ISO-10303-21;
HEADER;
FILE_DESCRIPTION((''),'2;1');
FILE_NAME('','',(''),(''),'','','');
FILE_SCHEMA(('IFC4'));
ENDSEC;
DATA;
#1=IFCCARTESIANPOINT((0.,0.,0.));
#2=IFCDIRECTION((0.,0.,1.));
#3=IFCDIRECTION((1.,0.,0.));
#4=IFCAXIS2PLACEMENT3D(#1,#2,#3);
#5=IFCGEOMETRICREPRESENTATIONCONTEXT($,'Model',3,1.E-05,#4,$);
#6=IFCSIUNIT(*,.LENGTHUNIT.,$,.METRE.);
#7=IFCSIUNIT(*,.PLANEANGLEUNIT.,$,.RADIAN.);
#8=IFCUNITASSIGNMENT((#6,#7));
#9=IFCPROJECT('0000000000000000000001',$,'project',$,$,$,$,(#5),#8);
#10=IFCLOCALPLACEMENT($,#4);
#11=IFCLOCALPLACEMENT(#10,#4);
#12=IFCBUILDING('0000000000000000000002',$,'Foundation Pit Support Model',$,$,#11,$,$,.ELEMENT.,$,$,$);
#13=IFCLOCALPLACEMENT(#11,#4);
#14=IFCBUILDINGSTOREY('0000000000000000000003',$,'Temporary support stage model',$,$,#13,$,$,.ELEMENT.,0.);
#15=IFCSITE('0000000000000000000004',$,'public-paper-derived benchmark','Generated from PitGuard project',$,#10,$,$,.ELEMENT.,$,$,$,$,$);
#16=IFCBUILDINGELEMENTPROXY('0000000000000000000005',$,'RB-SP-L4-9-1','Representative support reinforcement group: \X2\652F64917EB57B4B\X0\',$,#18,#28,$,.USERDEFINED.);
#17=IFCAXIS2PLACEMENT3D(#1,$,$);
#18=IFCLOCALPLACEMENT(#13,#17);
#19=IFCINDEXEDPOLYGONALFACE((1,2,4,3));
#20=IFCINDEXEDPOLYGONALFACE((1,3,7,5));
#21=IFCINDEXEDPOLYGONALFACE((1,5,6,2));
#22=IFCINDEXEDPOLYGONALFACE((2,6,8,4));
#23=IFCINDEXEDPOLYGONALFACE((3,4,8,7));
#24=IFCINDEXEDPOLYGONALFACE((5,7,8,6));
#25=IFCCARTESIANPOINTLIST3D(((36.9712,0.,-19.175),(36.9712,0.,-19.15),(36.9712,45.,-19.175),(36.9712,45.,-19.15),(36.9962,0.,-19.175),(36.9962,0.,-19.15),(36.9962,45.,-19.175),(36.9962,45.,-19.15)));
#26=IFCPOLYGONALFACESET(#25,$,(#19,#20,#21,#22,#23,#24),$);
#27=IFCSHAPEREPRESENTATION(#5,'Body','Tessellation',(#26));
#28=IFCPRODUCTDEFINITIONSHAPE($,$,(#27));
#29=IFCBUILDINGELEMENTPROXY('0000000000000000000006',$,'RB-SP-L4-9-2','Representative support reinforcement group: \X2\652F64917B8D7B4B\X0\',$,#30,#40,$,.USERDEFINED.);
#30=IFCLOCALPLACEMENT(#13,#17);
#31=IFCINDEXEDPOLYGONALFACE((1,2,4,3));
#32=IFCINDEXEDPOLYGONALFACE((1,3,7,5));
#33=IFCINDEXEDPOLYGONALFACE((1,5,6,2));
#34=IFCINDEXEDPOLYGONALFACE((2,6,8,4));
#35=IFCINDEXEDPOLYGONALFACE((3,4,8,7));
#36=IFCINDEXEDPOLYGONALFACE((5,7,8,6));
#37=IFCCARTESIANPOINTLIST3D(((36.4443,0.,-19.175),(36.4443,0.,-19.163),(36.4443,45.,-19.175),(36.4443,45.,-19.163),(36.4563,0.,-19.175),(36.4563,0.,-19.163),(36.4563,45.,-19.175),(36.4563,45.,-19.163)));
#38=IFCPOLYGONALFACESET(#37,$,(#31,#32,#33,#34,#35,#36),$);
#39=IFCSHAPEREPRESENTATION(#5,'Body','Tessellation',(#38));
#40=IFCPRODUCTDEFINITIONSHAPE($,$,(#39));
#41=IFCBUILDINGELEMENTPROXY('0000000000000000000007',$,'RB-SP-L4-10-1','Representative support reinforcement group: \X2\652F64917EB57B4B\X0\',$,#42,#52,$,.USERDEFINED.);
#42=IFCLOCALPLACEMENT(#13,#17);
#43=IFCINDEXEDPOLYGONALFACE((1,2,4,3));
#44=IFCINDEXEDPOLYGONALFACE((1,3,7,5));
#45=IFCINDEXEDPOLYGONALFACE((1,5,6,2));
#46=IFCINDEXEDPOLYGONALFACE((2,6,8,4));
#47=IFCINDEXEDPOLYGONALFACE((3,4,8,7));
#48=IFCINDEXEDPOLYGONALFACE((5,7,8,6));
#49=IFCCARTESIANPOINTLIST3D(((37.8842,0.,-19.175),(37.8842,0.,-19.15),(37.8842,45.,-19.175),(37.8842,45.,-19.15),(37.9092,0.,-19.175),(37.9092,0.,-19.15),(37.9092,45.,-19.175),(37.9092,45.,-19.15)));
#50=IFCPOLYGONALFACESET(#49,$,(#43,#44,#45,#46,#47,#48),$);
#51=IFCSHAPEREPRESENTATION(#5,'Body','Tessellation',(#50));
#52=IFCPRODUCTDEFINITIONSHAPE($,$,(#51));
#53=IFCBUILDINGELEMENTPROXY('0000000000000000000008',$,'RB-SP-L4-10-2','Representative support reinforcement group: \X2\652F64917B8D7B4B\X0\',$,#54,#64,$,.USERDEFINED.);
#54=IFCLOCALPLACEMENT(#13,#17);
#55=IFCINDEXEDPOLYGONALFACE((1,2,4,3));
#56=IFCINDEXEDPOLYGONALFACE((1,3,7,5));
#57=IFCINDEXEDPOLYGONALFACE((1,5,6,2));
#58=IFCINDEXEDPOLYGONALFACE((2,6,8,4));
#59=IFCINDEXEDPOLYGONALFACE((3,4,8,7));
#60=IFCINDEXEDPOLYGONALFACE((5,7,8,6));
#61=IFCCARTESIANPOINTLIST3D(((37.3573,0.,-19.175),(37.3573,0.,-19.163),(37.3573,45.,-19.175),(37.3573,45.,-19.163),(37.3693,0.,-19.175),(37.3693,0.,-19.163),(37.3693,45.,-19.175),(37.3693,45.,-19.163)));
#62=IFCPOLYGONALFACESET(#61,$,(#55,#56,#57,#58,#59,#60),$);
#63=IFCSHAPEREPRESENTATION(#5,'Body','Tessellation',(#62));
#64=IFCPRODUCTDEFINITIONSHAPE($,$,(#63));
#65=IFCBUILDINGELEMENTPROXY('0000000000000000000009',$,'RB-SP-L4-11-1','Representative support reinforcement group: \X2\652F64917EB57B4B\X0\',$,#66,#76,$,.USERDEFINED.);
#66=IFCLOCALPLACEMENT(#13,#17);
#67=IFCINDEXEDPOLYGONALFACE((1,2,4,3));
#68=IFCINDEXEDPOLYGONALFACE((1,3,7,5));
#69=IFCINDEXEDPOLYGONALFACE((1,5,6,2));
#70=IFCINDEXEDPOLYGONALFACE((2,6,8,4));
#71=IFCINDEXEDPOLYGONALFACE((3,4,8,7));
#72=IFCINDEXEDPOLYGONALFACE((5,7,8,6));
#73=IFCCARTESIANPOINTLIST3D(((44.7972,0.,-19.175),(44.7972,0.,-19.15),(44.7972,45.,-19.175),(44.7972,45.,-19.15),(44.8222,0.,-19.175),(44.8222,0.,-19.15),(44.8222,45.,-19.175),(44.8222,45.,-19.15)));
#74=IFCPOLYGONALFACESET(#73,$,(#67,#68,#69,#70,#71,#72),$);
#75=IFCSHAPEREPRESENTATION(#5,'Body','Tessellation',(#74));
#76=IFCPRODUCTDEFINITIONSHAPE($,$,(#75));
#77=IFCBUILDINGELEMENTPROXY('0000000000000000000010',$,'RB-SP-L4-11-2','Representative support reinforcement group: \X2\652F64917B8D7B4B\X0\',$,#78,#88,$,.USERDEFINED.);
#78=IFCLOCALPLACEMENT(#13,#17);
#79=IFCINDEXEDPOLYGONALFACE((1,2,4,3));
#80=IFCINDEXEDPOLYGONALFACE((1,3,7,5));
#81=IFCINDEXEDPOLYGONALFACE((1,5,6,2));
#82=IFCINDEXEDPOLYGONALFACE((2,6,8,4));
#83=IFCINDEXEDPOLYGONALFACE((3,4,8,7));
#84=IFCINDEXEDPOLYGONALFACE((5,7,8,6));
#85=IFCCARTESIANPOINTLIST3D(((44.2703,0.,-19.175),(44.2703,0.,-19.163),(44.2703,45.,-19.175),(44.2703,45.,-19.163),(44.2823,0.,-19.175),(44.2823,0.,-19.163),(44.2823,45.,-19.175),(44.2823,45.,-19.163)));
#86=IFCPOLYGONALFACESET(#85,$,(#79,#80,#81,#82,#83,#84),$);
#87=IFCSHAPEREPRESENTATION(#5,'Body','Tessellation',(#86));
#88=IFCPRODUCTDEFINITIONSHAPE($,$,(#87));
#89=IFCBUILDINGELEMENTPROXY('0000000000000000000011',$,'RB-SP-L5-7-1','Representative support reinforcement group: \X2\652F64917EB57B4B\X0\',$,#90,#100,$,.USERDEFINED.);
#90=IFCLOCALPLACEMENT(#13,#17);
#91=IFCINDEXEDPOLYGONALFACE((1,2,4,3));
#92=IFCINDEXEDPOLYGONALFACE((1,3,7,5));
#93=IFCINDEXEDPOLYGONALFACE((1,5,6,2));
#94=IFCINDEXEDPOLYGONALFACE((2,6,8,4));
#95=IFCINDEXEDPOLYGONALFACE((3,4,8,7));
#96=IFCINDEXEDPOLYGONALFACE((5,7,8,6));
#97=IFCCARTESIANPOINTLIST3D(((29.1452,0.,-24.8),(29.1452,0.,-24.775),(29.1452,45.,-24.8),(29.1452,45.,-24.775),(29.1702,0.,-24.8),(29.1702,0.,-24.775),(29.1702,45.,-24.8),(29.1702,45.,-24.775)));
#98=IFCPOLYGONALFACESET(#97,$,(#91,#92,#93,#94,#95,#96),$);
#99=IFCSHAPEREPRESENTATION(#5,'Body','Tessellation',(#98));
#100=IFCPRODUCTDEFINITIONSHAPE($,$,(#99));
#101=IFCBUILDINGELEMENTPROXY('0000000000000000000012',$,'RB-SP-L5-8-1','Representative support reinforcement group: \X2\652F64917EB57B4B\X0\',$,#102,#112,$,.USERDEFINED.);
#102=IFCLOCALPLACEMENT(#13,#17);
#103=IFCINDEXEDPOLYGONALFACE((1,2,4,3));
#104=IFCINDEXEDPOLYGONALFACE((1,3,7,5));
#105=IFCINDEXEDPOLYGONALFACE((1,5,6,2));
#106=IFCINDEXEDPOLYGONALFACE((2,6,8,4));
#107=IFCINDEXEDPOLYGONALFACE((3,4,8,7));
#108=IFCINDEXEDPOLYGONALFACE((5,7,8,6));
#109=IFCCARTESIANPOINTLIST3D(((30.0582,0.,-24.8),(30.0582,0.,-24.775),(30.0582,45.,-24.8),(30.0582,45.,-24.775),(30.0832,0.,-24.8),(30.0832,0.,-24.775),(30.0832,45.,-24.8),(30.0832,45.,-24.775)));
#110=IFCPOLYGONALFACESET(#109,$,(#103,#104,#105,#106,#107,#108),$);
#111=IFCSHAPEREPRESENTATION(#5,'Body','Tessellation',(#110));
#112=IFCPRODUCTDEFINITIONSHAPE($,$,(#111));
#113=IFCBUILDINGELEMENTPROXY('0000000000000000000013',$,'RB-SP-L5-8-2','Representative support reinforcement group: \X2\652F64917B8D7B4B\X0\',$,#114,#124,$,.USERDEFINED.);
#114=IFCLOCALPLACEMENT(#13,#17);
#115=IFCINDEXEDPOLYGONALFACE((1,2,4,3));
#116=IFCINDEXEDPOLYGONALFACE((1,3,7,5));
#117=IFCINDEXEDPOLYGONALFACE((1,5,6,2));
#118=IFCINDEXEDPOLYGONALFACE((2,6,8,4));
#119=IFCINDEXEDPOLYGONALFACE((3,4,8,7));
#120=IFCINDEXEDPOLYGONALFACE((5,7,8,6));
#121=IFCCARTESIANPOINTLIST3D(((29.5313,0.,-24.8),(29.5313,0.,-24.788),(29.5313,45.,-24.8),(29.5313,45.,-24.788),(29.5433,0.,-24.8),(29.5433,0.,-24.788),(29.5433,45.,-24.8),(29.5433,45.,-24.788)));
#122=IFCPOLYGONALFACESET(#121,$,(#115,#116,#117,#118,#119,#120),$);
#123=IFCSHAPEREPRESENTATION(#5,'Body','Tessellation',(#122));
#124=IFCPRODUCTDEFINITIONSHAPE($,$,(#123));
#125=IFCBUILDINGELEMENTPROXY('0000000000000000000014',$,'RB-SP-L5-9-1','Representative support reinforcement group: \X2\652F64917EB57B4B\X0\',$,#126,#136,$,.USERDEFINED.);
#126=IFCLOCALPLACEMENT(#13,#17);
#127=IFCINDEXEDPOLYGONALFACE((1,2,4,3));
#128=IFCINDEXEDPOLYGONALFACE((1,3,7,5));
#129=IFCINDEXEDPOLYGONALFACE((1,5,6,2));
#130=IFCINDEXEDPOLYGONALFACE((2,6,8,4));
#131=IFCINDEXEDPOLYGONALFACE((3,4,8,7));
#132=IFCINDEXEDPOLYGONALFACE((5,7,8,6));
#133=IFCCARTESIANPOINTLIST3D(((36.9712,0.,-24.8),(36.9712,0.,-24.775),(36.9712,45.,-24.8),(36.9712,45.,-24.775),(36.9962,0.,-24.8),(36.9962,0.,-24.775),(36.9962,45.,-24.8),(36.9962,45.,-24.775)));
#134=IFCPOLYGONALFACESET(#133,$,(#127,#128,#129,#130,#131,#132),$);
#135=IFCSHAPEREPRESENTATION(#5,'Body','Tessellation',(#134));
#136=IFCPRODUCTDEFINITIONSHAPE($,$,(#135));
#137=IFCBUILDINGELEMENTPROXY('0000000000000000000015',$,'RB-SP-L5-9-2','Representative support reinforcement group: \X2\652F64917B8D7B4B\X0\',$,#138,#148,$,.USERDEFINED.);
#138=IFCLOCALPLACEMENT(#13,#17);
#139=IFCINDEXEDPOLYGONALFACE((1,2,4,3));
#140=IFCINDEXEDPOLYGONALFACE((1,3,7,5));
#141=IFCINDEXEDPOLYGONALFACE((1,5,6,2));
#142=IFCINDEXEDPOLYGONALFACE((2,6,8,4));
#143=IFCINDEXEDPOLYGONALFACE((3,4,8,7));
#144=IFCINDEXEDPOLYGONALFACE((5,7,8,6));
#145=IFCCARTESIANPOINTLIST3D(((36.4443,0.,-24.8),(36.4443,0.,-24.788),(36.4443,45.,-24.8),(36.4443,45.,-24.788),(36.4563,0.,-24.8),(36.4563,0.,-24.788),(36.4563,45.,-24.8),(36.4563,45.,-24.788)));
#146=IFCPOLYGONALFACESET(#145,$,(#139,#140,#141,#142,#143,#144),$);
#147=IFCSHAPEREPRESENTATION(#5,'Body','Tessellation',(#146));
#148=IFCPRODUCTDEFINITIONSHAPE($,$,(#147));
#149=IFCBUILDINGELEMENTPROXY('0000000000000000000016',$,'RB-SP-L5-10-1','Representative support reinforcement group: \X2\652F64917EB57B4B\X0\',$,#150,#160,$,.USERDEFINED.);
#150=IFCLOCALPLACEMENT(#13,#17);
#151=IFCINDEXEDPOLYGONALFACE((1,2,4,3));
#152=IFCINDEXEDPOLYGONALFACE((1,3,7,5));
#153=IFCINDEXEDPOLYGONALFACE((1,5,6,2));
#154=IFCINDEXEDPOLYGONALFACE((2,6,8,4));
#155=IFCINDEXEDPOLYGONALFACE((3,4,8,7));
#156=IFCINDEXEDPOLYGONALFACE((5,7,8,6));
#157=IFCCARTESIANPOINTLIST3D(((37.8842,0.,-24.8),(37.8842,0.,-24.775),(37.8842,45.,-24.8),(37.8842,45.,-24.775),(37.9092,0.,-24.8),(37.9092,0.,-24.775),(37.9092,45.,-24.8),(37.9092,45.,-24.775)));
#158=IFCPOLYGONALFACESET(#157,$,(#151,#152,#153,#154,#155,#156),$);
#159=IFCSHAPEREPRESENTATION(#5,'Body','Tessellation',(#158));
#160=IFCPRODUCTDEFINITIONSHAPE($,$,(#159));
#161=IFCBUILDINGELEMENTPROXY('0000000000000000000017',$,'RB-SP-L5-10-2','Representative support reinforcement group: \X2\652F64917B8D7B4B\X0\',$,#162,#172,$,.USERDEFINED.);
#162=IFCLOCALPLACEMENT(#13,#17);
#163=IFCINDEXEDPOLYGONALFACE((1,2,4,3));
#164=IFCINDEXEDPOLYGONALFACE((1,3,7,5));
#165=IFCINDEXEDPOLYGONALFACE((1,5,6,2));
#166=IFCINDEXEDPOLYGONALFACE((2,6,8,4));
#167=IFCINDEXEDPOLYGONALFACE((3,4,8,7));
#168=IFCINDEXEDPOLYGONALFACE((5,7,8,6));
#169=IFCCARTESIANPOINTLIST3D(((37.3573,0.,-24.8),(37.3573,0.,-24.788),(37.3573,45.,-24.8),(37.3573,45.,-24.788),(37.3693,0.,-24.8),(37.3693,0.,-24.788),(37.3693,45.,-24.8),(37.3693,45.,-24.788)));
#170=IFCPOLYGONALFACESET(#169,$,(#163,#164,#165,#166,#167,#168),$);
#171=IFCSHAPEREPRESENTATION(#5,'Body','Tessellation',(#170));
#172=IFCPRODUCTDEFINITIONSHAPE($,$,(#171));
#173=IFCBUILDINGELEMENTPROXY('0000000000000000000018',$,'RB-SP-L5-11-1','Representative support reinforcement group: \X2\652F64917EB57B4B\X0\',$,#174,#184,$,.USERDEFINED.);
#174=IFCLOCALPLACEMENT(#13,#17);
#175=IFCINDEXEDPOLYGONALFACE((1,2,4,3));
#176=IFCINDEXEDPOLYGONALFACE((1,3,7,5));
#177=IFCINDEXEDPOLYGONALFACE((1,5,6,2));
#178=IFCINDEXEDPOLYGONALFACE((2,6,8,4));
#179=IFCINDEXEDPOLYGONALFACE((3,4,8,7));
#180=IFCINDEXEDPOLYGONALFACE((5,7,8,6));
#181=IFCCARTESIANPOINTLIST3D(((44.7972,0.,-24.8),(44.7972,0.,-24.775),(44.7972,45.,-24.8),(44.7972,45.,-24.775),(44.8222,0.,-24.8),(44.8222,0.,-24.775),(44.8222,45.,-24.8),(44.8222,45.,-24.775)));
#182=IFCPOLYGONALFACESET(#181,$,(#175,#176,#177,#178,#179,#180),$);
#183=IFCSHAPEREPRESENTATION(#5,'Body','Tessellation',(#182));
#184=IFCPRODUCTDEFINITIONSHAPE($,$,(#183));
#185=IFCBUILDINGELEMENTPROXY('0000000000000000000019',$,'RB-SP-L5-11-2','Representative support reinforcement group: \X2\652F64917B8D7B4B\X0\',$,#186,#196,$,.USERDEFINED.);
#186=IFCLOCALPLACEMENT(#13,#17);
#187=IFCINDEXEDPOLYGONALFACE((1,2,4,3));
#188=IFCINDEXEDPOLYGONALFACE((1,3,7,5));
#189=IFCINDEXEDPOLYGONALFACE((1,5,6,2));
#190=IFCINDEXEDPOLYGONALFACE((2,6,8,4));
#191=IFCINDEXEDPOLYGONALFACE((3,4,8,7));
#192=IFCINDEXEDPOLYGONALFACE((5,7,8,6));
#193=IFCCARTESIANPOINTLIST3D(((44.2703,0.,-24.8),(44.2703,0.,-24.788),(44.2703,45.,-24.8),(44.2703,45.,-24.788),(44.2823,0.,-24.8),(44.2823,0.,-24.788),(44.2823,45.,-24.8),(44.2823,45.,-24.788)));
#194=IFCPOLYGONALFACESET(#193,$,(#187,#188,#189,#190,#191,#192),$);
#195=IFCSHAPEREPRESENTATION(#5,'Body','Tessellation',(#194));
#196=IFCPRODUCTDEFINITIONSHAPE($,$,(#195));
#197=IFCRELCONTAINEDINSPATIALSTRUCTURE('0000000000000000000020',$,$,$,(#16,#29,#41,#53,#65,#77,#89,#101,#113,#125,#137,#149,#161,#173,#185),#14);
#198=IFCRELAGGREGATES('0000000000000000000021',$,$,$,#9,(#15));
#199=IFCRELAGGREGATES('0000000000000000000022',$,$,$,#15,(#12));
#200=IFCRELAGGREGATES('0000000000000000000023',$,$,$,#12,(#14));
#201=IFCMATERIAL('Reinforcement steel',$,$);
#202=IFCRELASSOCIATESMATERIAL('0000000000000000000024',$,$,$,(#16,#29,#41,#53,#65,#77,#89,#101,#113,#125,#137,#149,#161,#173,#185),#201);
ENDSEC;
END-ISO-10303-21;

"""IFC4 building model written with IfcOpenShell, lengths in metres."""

from ifc_helpers import new_model, si_unit, frame, origin_with_axes, origin_2d, place, context, project, spatial, rectangle, extrude, material, element, save


model = new_model("IFC4")

# Units and contexts
model_context = context("Model", 3, precision=1e-05, world=origin_with_axes())
ifc_project = project(units=[si_unit("LENGTHUNIT", "METRE"), si_unit("PLANEANGLEUNIT", "RADIAN")], contexts=[model_context])

# Site, building, storey
site_placement = place(None, origin_with_axes())
site = spatial("IfcSite", under=ifc_project, at=site_placement, Name="public-paper-derived benchmark", Description="Generated from PitGuard project", CompositionType="ELEMENT")
building_placement = place(site_placement, origin_with_axes())
building = spatial("IfcBuilding", under=site, at=building_placement, Name="Foundation Pit Support Model", CompositionType="ELEMENT")
storey_placement = place(building_placement, origin_with_axes())
storey = spatial("IfcBuildingStorey", under=building, at=storey_placement, Name="Temporary support stage model", CompositionType="ELEMENT", Elevation=0.0)

# Building element proxies
ifc_material_1 = material(Name="Reinforcement steel")
proxy_1_placement = place(storey_placement, frame((36.9837, 22.5, -19.175), z_axis=(0.0, 0.0, 1.0), x_axis=(0.0, 1.0, 0.0)))
element("IfcBuildingElementProxy", 1, at=proxy_1_placement, inside=storey, material=ifc_material_1, Name="RB-SP-L4-9-1", Description="Representative support reinforcement group: 支撑纵筋", PredefinedType="USERDEFINED", context=model_context, shape_type="SweptSolid", body=[
    extrude(rectangle(XDim=45.0, YDim=0.025, at=origin_2d()), origin_with_axes(), (0.0, 0.0, 1.0), 0.025),
])
proxy_2_placement = place(storey_placement, frame((36.4503, 22.5, -19.175), z_axis=(0.0, 0.0, 1.0), x_axis=(0.0, 1.0, 0.0)))
element("IfcBuildingElementProxy", 2, at=proxy_2_placement, inside=storey, material=ifc_material_1, Name="RB-SP-L4-9-2", Description="Representative support reinforcement group: 支撑箍筋", PredefinedType="USERDEFINED", context=model_context, shape_type="SweptSolid", body=[
    extrude(rectangle(XDim=45.0, YDim=0.012, at=origin_2d()), origin_with_axes(), (0.0, 0.0, 1.0), 0.012),
])
proxy_3_placement = place(storey_placement, frame((37.8967, 22.5, -19.175), z_axis=(0.0, 0.0, 1.0), x_axis=(0.0, 1.0, 0.0)))
element("IfcBuildingElementProxy", 3, at=proxy_3_placement, inside=storey, material=ifc_material_1, Name="RB-SP-L4-10-1", Description="Representative support reinforcement group: 支撑纵筋", PredefinedType="USERDEFINED", context=model_context, shape_type="SweptSolid", body=[
    extrude(rectangle(XDim=45.0, YDim=0.025, at=origin_2d()), origin_with_axes(), (0.0, 0.0, 1.0), 0.025),
])
proxy_4_placement = place(storey_placement, frame((37.3633, 22.5, -19.175), z_axis=(0.0, 0.0, 1.0), x_axis=(0.0, 1.0, 0.0)))
element("IfcBuildingElementProxy", 4, at=proxy_4_placement, inside=storey, material=ifc_material_1, Name="RB-SP-L4-10-2", Description="Representative support reinforcement group: 支撑箍筋", PredefinedType="USERDEFINED", context=model_context, shape_type="SweptSolid", body=[
    extrude(rectangle(XDim=45.0, YDim=0.012, at=origin_2d()), origin_with_axes(), (0.0, 0.0, 1.0), 0.012),
])
proxy_5_placement = place(storey_placement, frame((44.8097, 22.5, -19.175), z_axis=(0.0, 0.0, 1.0), x_axis=(0.0, 1.0, 0.0)))
element("IfcBuildingElementProxy", 5, at=proxy_5_placement, inside=storey, material=ifc_material_1, Name="RB-SP-L4-11-1", Description="Representative support reinforcement group: 支撑纵筋", PredefinedType="USERDEFINED", context=model_context, shape_type="SweptSolid", body=[
    extrude(rectangle(XDim=45.0, YDim=0.025, at=origin_2d()), origin_with_axes(), (0.0, 0.0, 1.0), 0.025),
])
proxy_6_placement = place(storey_placement, frame((44.2763, 22.5, -19.175), z_axis=(0.0, 0.0, 1.0), x_axis=(0.0, 1.0, 0.0)))
element("IfcBuildingElementProxy", 6, at=proxy_6_placement, inside=storey, material=ifc_material_1, Name="RB-SP-L4-11-2", Description="Representative support reinforcement group: 支撑箍筋", PredefinedType="USERDEFINED", context=model_context, shape_type="SweptSolid", body=[
    extrude(rectangle(XDim=45.0, YDim=0.012, at=origin_2d()), origin_with_axes(), (0.0, 0.0, 1.0), 0.012),
])
for number, where, z_axis, x_axis, name in (
    (7, (29.1577, 22.5, -24.8), (0.0, 0.0, 1.0), (0.0, 1.0, 0.0), "RB-SP-L5-7-1"),
    (8, (30.0707, 22.5, -24.8), (0.0, 0.0, 1.0), (0.0, 1.0, 0.0), "RB-SP-L5-8-1"),
):
    element("IfcBuildingElementProxy", number, at=place(storey_placement, frame(where, z_axis=z_axis, x_axis=x_axis)), inside=storey, material=ifc_material_1, Name=name, Description="Representative support reinforcement group: 支撑纵筋", PredefinedType="USERDEFINED", context=model_context, shape_type="SweptSolid", body=[
        extrude(rectangle(XDim=45.0, YDim=0.025, at=origin_2d()), origin_with_axes(), (0.0, 0.0, 1.0), 0.025),
    ])
proxy_7_placement = place(storey_placement, frame((29.5373, 22.5, -24.8), z_axis=(0.0, 0.0, 1.0), x_axis=(0.0, 1.0, 0.0)))
element("IfcBuildingElementProxy", 9, at=proxy_7_placement, inside=storey, material=ifc_material_1, Name="RB-SP-L5-8-2", Description="Representative support reinforcement group: 支撑箍筋", PredefinedType="USERDEFINED", context=model_context, shape_type="SweptSolid", body=[
    extrude(rectangle(XDim=45.0, YDim=0.012, at=origin_2d()), origin_with_axes(), (0.0, 0.0, 1.0), 0.012),
])
proxy_8_placement = place(storey_placement, frame((36.9837, 22.5, -24.8), z_axis=(0.0, 0.0, 1.0), x_axis=(0.0, 1.0, 0.0)))
element("IfcBuildingElementProxy", 10, at=proxy_8_placement, inside=storey, material=ifc_material_1, Name="RB-SP-L5-9-1", Description="Representative support reinforcement group: 支撑纵筋", PredefinedType="USERDEFINED", context=model_context, shape_type="SweptSolid", body=[
    extrude(rectangle(XDim=45.0, YDim=0.025, at=origin_2d()), origin_with_axes(), (0.0, 0.0, 1.0), 0.025),
])
proxy_9_placement = place(storey_placement, frame((36.4503, 22.5, -24.8), z_axis=(0.0, 0.0, 1.0), x_axis=(0.0, 1.0, 0.0)))
element("IfcBuildingElementProxy", 11, at=proxy_9_placement, inside=storey, material=ifc_material_1, Name="RB-SP-L5-9-2", Description="Representative support reinforcement group: 支撑箍筋", PredefinedType="USERDEFINED", context=model_context, shape_type="SweptSolid", body=[
    extrude(rectangle(XDim=45.0, YDim=0.012, at=origin_2d()), origin_with_axes(), (0.0, 0.0, 1.0), 0.012),
])
proxy_10_placement = place(storey_placement, frame((37.8967, 22.5, -24.8), z_axis=(0.0, 0.0, 1.0), x_axis=(0.0, 1.0, 0.0)))
element("IfcBuildingElementProxy", 12, at=proxy_10_placement, inside=storey, material=ifc_material_1, Name="RB-SP-L5-10-1", Description="Representative support reinforcement group: 支撑纵筋", PredefinedType="USERDEFINED", context=model_context, shape_type="SweptSolid", body=[
    extrude(rectangle(XDim=45.0, YDim=0.025, at=origin_2d()), origin_with_axes(), (0.0, 0.0, 1.0), 0.025),
])
proxy_11_placement = place(storey_placement, frame((37.3633, 22.5, -24.8), z_axis=(0.0, 0.0, 1.0), x_axis=(0.0, 1.0, 0.0)))
element("IfcBuildingElementProxy", 13, at=proxy_11_placement, inside=storey, material=ifc_material_1, Name="RB-SP-L5-10-2", Description="Representative support reinforcement group: 支撑箍筋", PredefinedType="USERDEFINED", context=model_context, shape_type="SweptSolid", body=[
    extrude(rectangle(XDim=45.0, YDim=0.012, at=origin_2d()), origin_with_axes(), (0.0, 0.0, 1.0), 0.012),
])
proxy_12_placement = place(storey_placement, frame((44.8097, 22.5, -24.8), z_axis=(0.0, 0.0, 1.0), x_axis=(0.0, 1.0, 0.0)))
element("IfcBuildingElementProxy", 14, at=proxy_12_placement, inside=storey, material=ifc_material_1, Name="RB-SP-L5-11-1", Description="Representative support reinforcement group: 支撑纵筋", PredefinedType="USERDEFINED", context=model_context, shape_type="SweptSolid", body=[
    extrude(rectangle(XDim=45.0, YDim=0.025, at=origin_2d()), origin_with_axes(), (0.0, 0.0, 1.0), 0.025),
])
proxy_13_placement = place(storey_placement, frame((44.2763, 22.5, -24.8), z_axis=(0.0, 0.0, 1.0), x_axis=(0.0, 1.0, 0.0)))
element("IfcBuildingElementProxy", 15, at=proxy_13_placement, inside=storey, material=ifc_material_1, Name="RB-SP-L5-11-2", Description="Representative support reinforcement group: 支撑箍筋", PredefinedType="USERDEFINED", context=model_context, shape_type="SweptSolid", body=[
    extrude(rectangle(XDim=45.0, YDim=0.012, at=origin_2d()), origin_with_axes(), (0.0, 0.0, 1.0), 0.012),
])

save(model, "model.ifc")
